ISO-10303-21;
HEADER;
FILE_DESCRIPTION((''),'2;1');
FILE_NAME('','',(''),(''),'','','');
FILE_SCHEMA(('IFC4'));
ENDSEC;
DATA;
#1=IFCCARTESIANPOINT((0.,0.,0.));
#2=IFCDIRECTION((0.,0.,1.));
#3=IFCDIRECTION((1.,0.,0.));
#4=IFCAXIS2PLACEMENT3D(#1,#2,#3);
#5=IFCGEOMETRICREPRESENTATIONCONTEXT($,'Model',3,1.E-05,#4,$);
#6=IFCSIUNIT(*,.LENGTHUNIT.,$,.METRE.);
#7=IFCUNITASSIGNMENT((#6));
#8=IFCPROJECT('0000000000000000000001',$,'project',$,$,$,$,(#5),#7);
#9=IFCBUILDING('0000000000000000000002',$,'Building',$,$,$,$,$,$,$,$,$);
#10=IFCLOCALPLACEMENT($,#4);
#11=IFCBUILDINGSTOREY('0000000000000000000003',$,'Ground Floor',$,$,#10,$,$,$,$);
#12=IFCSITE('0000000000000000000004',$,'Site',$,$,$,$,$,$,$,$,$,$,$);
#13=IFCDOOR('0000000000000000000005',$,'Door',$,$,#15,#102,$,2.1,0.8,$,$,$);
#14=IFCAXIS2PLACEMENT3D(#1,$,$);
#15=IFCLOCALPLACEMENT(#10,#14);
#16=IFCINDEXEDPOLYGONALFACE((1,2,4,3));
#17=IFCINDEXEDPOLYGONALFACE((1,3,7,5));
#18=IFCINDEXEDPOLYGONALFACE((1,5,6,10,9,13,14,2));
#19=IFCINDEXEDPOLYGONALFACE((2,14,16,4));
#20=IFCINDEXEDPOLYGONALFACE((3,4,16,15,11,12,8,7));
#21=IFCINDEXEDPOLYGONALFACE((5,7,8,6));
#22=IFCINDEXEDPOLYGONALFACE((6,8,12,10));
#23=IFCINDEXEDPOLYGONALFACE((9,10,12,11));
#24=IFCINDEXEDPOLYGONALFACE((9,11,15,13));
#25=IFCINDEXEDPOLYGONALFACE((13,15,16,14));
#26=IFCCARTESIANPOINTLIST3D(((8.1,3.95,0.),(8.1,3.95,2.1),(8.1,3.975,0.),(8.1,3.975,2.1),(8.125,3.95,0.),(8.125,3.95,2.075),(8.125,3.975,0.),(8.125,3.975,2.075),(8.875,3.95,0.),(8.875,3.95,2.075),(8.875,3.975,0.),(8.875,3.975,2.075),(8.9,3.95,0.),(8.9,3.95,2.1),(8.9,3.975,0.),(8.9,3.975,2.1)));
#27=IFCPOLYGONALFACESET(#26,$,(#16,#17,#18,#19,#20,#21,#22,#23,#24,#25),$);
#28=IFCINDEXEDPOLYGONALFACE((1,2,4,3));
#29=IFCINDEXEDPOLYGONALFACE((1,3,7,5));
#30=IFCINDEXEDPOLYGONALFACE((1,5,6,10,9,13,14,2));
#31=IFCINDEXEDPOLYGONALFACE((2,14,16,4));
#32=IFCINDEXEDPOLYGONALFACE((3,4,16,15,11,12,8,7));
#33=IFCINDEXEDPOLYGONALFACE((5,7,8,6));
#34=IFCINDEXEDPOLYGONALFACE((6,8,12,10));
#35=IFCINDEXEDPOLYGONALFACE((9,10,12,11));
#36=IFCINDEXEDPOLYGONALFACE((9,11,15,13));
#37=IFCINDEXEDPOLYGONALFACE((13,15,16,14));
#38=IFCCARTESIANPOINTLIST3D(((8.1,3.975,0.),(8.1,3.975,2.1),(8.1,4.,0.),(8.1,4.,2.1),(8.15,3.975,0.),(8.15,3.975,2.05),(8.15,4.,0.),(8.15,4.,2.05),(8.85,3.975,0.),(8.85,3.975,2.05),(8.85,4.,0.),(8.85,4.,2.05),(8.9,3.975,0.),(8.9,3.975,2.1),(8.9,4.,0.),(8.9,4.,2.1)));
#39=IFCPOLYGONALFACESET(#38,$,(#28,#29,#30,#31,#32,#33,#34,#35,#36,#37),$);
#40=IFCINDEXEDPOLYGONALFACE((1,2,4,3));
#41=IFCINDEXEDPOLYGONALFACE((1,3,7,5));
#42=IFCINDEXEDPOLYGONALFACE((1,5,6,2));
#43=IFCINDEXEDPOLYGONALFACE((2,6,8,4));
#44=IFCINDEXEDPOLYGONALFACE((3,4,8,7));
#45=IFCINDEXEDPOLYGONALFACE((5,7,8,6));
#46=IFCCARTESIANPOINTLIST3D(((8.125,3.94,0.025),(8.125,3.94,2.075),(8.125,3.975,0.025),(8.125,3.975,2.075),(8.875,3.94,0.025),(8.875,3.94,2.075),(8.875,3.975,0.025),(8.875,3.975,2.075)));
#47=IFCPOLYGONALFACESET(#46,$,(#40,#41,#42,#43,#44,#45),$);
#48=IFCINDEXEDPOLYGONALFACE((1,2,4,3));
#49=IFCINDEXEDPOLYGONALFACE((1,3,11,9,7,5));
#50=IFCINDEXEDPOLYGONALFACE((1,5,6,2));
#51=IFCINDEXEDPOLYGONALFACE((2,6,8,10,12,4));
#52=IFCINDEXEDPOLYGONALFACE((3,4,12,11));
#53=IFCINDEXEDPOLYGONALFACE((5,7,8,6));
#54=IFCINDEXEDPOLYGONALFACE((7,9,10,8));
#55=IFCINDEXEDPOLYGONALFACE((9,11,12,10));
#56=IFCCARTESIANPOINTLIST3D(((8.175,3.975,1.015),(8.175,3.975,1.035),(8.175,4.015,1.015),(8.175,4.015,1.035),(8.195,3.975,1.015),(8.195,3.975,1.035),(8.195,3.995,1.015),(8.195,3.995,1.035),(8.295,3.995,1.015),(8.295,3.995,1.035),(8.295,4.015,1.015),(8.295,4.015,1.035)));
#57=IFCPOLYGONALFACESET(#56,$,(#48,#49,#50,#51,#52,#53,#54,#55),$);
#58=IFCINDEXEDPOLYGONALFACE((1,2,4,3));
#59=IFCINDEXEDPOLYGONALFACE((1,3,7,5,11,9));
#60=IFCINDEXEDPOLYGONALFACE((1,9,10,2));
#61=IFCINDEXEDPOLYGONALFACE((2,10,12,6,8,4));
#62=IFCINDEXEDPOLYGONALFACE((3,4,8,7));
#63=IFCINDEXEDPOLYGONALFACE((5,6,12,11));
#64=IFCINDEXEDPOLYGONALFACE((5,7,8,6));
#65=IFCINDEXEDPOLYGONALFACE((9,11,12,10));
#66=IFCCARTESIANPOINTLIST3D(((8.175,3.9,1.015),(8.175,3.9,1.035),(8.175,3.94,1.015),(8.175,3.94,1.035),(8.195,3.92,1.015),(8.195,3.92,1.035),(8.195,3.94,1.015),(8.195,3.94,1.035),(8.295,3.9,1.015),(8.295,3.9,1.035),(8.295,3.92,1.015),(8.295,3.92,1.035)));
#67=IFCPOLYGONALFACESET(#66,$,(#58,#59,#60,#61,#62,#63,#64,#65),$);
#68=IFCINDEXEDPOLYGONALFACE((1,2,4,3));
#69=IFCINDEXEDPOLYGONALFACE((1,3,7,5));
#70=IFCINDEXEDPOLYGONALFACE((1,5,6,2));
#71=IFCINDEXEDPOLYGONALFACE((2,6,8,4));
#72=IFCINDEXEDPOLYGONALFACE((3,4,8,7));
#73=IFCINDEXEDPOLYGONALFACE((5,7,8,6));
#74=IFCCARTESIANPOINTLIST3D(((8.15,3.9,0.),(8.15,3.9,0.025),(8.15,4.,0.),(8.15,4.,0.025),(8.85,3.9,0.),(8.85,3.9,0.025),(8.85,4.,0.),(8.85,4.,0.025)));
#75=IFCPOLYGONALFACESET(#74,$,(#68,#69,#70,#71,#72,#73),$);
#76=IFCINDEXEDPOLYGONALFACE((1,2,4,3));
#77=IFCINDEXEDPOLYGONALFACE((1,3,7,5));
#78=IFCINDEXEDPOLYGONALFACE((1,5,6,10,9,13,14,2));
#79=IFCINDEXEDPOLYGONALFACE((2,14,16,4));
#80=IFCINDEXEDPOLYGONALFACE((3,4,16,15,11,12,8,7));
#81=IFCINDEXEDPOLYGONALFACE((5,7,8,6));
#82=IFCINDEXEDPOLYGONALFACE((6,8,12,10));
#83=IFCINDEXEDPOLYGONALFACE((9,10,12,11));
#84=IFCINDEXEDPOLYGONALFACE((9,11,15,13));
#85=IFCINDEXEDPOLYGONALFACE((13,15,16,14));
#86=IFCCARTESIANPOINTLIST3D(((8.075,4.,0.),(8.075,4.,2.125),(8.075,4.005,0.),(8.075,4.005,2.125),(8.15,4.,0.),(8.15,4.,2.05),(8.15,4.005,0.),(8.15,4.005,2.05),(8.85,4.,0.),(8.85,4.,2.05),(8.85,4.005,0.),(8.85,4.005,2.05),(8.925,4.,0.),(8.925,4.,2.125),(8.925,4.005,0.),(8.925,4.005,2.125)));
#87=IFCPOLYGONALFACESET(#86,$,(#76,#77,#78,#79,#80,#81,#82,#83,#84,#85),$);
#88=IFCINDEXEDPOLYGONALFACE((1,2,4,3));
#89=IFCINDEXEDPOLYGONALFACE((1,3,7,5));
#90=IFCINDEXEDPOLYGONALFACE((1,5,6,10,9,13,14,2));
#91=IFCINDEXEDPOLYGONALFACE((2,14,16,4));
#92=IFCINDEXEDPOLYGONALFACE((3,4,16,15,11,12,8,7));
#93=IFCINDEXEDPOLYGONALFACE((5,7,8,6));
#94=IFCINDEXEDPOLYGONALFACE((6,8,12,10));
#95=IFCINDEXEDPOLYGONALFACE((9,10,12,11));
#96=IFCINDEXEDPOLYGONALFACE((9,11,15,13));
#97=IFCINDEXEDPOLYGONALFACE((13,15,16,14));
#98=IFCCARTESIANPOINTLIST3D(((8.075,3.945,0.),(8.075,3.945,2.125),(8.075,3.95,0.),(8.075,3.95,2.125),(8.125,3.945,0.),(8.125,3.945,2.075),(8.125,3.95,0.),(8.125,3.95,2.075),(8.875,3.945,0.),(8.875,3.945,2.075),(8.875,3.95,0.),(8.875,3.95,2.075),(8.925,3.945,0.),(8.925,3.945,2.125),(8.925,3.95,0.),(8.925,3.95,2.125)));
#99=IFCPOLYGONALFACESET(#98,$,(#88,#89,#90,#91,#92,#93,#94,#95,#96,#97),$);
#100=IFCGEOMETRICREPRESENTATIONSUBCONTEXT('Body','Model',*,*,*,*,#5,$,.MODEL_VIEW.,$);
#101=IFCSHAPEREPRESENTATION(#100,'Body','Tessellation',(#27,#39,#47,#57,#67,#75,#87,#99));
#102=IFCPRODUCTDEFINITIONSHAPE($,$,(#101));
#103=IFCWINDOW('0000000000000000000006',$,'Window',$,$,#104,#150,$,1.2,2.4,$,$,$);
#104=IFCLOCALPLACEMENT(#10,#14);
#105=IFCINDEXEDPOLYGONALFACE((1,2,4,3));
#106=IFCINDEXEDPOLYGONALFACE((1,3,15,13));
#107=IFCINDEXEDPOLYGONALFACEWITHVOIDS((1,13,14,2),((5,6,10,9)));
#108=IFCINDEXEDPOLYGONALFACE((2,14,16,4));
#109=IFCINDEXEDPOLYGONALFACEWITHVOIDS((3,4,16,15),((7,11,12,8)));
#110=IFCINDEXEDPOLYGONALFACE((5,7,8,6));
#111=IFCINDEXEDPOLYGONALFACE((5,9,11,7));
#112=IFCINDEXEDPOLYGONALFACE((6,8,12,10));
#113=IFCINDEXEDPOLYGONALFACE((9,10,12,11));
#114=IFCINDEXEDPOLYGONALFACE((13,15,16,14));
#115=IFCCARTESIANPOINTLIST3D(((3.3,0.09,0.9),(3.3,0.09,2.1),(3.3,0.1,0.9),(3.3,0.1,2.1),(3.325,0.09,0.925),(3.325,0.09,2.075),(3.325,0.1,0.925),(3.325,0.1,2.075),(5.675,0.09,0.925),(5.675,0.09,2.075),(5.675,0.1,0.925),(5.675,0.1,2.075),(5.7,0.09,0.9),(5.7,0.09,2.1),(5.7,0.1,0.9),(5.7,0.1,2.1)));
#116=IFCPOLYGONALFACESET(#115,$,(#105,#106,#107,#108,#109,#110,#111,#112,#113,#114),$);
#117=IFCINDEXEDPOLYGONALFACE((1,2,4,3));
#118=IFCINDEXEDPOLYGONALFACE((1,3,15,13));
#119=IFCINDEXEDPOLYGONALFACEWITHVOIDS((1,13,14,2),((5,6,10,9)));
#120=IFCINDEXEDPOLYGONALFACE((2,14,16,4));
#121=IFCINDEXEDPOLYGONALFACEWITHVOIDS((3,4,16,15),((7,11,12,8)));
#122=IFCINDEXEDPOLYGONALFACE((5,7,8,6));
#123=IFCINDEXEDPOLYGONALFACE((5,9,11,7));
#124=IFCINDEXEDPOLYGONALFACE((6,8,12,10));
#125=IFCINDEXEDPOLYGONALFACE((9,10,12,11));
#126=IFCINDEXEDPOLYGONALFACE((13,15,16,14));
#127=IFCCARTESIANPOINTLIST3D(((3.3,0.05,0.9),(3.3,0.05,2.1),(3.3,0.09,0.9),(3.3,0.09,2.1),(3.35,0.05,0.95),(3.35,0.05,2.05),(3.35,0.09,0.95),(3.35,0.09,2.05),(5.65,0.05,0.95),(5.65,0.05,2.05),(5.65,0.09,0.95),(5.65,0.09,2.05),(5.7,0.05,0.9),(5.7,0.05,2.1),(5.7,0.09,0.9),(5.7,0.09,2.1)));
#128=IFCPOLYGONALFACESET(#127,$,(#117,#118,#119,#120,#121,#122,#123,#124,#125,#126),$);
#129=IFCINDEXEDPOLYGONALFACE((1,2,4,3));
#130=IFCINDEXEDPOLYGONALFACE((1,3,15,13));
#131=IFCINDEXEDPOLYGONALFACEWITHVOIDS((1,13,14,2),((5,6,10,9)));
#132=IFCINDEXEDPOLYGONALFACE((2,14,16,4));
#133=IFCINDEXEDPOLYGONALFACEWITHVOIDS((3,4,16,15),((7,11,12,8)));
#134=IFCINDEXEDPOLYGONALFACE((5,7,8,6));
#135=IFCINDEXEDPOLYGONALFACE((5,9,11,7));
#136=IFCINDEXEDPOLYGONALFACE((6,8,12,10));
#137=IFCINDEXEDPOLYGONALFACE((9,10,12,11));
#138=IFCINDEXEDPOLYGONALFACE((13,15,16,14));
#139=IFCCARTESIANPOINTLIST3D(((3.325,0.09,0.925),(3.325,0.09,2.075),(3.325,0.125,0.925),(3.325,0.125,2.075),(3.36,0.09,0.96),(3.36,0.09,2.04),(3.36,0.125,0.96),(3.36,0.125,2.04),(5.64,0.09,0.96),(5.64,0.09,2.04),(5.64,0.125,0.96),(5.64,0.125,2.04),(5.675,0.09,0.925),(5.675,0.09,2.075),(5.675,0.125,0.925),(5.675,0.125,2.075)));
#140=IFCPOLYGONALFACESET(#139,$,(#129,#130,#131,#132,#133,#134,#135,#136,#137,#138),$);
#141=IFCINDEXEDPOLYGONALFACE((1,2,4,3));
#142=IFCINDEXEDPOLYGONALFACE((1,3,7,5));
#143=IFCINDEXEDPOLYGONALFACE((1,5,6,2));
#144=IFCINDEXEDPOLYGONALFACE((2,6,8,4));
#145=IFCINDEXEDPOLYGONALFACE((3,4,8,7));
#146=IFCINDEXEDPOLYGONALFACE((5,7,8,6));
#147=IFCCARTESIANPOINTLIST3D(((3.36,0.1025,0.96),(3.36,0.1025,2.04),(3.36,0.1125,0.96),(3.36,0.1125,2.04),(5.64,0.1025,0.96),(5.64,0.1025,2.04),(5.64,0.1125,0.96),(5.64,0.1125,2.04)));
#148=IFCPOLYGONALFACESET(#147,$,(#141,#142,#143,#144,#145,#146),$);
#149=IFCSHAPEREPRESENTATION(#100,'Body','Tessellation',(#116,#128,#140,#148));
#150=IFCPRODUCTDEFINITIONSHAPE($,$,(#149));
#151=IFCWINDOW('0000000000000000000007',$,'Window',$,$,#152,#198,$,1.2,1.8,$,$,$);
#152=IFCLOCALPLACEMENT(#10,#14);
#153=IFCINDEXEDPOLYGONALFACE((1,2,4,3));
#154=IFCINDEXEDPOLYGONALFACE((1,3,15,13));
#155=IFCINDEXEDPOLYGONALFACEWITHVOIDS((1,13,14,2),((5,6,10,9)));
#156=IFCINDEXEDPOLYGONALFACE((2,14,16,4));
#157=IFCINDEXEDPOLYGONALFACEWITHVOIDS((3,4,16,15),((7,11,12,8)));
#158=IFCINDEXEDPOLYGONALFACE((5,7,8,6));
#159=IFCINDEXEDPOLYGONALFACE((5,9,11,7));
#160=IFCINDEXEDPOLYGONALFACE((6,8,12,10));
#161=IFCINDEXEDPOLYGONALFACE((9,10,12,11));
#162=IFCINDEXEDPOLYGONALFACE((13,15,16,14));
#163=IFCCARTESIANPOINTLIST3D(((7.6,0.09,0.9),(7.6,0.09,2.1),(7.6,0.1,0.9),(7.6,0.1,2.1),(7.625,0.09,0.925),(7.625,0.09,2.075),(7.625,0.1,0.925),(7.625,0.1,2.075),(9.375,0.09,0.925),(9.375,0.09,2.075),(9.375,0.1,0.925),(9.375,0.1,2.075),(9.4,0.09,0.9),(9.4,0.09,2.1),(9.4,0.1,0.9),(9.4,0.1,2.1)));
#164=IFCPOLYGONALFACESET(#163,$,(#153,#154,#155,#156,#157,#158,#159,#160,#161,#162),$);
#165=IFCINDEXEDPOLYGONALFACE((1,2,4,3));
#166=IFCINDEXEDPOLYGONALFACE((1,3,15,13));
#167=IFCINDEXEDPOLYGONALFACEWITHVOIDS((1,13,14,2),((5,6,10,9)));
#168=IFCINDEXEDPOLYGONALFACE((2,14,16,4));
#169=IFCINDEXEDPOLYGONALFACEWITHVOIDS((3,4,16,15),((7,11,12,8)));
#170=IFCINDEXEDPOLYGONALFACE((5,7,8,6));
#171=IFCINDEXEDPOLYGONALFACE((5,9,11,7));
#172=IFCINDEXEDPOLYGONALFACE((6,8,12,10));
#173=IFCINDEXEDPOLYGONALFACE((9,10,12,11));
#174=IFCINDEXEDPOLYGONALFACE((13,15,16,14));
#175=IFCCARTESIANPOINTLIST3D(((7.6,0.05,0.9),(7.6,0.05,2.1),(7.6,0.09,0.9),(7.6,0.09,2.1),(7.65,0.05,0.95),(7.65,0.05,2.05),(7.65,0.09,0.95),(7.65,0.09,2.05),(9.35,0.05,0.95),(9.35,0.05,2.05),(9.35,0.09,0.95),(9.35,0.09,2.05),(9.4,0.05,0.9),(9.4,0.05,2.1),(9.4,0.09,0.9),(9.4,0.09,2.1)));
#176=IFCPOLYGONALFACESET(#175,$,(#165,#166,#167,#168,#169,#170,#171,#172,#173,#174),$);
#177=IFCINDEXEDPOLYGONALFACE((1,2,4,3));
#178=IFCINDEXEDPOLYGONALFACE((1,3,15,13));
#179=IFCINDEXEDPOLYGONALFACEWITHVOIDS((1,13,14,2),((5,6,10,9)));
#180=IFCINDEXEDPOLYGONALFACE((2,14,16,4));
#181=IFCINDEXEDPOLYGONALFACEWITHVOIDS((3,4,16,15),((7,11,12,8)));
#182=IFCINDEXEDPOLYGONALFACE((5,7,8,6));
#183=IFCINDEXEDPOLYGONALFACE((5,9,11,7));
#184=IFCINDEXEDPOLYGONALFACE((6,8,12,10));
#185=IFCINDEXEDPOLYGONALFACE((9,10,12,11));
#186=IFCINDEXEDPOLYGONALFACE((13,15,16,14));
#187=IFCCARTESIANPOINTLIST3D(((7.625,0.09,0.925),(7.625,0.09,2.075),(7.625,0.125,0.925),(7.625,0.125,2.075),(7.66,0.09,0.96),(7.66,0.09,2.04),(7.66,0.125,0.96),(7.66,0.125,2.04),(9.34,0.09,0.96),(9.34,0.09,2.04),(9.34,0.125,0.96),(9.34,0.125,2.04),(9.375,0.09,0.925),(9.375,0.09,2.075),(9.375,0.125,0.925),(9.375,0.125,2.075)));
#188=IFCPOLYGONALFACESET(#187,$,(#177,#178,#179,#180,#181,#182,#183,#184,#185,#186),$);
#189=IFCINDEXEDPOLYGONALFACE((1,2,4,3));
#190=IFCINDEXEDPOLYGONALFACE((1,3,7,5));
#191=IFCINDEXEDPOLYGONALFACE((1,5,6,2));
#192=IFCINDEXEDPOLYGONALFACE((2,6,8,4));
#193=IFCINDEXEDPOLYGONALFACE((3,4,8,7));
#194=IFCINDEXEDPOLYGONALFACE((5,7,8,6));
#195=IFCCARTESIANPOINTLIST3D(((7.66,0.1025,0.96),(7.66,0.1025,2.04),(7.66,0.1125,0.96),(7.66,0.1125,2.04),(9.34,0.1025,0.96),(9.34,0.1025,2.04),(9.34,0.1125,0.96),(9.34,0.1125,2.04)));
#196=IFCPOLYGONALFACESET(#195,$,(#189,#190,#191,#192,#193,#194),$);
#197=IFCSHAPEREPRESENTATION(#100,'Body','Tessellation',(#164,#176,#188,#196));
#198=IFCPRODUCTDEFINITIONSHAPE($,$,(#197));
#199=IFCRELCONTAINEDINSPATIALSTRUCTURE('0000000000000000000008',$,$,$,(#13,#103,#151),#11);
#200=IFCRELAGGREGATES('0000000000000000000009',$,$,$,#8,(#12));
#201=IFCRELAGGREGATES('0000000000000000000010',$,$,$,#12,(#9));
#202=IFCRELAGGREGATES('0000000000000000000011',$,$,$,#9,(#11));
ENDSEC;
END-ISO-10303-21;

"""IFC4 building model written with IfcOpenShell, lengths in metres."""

from ifc_helpers import new_model, si_unit, frame, origin_with_axes, place, context, subcontext, project, spatial, line, indexed_curve, outline, extrude, element, save


model = new_model("IFC4")

# Units and contexts
model_context = context("Model", 3, precision=1e-05, world=origin_with_axes())
body_context = subcontext(model_context, "Body", "Model", "MODEL_VIEW")
ifc_project = project(units=[si_unit("LENGTHUNIT", "METRE")], contexts=[model_context])

# Site, building, storey
site = spatial("IfcSite", under=ifc_project, Name="Site")
building = spatial("IfcBuilding", under=site, Name="Building")
storey_placement = place(None, origin_with_axes())
storey = spatial("IfcBuildingStorey", under=building, at=storey_placement, Name="Ground Floor")

# Door
door_1_placement = place(storey_placement, frame((8.9, 4.0, 0.0), z_axis=(0.0, 0.0, 1.0), x_axis=(-1.0, 0.0, 0.0)))
element("IfcDoor", 1, at=door_1_placement, inside=storey, Name="Door", OverallHeight=2.1, OverallWidth=0.8, context=body_context, shape_type="SweptSolid", body=[
    extrude(outline(indexed_curve([(0.0, 0.0), (0.0, 2.1), (0.8, 2.1), (0.8, 0.0), (0.775, 0.0), (0.775, 2.075), (0.025, 2.075), (0.025, 0.0)], segments=[line(1, 2, 3, 4, 5, 6, 7, 8, 1)])), frame((0.0, 0.025, 0.0), z_axis=(0.0, -1.0, 0.0), x_axis=(1.0, 0.0, 0.0)), (0.0, 0.0, -1.0), 0.025),
    extrude(outline(indexed_curve([(0.0, 0.0), (0.0, 2.1), (0.8, 2.1), (0.8, 0.0), (0.75, 0.0), (0.75, 2.05), (0.05, 2.05), (0.05, 0.0)], segments=[line(1, 2, 3, 4, 5, 6, 7, 8, 1)])), frame((0.0, 0.0, 0.0), z_axis=(0.0, -1.0, 0.0), x_axis=(1.0, 0.0, 0.0)), (0.0, 0.0, -1.0), 0.025),
    extrude(outline(indexed_curve([(0.0, 0.0), (0.75, 0.0), (0.75, 0.035), (0.0, 0.035)], segments=[line(1, 2, 3, 4, 1)])), frame((0.025, 0.025, 0.025), z_axis=(0.0, 0.0, 1.0), x_axis=(1.0, 0.0, 0.0)), (0.0, 0.0, 1.0), 2.05),
    extrude(outline(indexed_curve([(0.0, 0.0), (0.0, -0.04), (-0.12, -0.04), (-0.12, -0.02), (-0.02, -0.02), (-0.02, 0.0)], segments=[line(1, 2, 3, 4, 5, 6, 1)])), frame((0.725, 0.025, 1.015), z_axis=(0.0, 0.0, 1.0), x_axis=(1.0, 0.0, 0.0)), (0.0, 0.0, 1.0), 0.02),
    extrude(outline(indexed_curve([(0.0, 0.0), (0.0, 0.04), (-0.12, 0.04), (-0.12, 0.02), (-0.02, 0.02), (-0.02, 0.0)], segments=[line(1, 2, 3, 4, 5, 6, 1)])), frame((0.725, 0.06, 1.015), z_axis=(0.0, 0.0, 1.0), x_axis=(1.0, 0.0, 0.0)), (0.0, 0.0, 1.0), 0.02),
    extrude(outline(indexed_curve([(0.0, 0.0), (0.7, 0.0), (0.7, 0.1), (0.0, 0.1)], segments=[line(1, 2, 3, 4, 1)])), frame((0.05, 0.0, 0.0), z_axis=(0.0, 0.0, 1.0), x_axis=(1.0, 0.0, 0.0)), (0.0, 0.0, 1.0), 0.025),
    extrude(outline(indexed_curve([(0.0, 0.0), (0.0, 2.125), (0.85, 2.125), (0.85, 0.0), (0.775, 0.0), (0.775, 2.05), (0.075, 2.05), (0.075, 0.0)], segments=[line(1, 2, 3, 4, 5, 6, 7, 8, 1)])), frame((-0.025, -0.005, 0.0), z_axis=(0.0, -1.0, 0.0), x_axis=(1.0, 0.0, 0.0)), (0.0, 0.0, -1.0), 0.005),
    extrude(outline(indexed_curve([(0.0, 0.0), (0.0, 2.125), (0.85, 2.125), (0.85, 0.0), (0.8, 0.0), (0.8, 2.075), (0.05, 2.075), (0.05, 0.0)], segments=[line(1, 2, 3, 4, 5, 6, 7, 8, 1)])), frame((-0.025, 0.05, 0.0), z_axis=(0.0, -1.0, 0.0), x_axis=(1.0, 0.0, 0.0)), (0.0, 0.0, -1.0), 0.005),
])

# Windows
window_1_placement = place(storey_placement, frame((3.3, 0.0, 0.9), z_axis=(0.0, 0.0, 1.0), x_axis=(1.0, 0.0, 0.0)))
element("IfcWindow", 2, at=window_1_placement, inside=storey, Name="Window", OverallHeight=1.2, OverallWidth=2.4, context=body_context, shape_type="SweptSolid", body=[
    extrude(outline(indexed_curve([(0.0, 0.0), (2.4, 0.0), (2.4, 1.2), (0.0, 1.2)], segments=[line(1, 2, 3, 4, 1)]), holes=[indexed_curve([(0.025, 0.025), (2.375, 0.025), (2.375, 1.175), (0.025, 1.175)], segments=[line(1, 2, 3, 4, 1)])]), frame((0.0, 0.09, 0.0), z_axis=(0.0, -1.0, 0.0), x_axis=(1.0, 0.0, 0.0)), (0.0, 0.0, -1.0), 0.01),
    extrude(outline(indexed_curve([(0.0, 0.0), (2.4, 0.0), (2.4, 1.2), (0.0, 1.2)], segments=[line(1, 2, 3, 4, 1)]), holes=[indexed_curve([(0.05, 0.05), (2.35, 0.05), (2.35, 1.15), (0.05, 1.15)], segments=[line(1, 2, 3, 4, 1)])]), frame((0.0, 0.05, 0.0), z_axis=(0.0, -1.0, 0.0), x_axis=(1.0, 0.0, 0.0)), (0.0, 0.0, -1.0), 0.04),
    extrude(outline(indexed_curve([(0.0, 0.0), (2.35, 0.0), (2.35, 1.15), (0.0, 1.15)], segments=[line(1, 2, 3, 4, 1)]), holes=[indexed_curve([(0.035, 0.035), (2.315, 0.035), (2.315, 1.115), (0.035, 1.115)], segments=[line(1, 2, 3, 4, 1)])]), frame((0.025, 0.09, 0.025), z_axis=(0.0, -1.0, 0.0), x_axis=(1.0, 0.0, 0.0)), (0.0, 0.0, -1.0), 0.035),
    extrude(outline(indexed_curve([(0.035, 0.035), (2.315, 0.035), (2.315, 1.115), (0.035, 1.115)], segments=[line(1, 2, 3, 4, 1)])), frame((0.025, 0.1025, 0.025), z_axis=(0.0, -1.0, 0.0), x_axis=(1.0, 0.0, 0.0)), (0.0, 0.0, -1.0), 0.01),
])
window_2_placement = place(storey_placement, frame((7.6, 0.0, 0.9), z_axis=(0.0, 0.0, 1.0), x_axis=(1.0, 0.0, 0.0)))
element("IfcWindow", 3, at=window_2_placement, inside=storey, Name="Window", OverallHeight=1.2, OverallWidth=1.8, context=body_context, shape_type="SweptSolid", body=[
    extrude(outline(indexed_curve([(0.0, 0.0), (1.8, 0.0), (1.8, 1.2), (0.0, 1.2)], segments=[line(1, 2, 3, 4, 1)]), holes=[indexed_curve([(0.025, 0.025), (1.775, 0.025), (1.775, 1.175), (0.025, 1.175)], segments=[line(1, 2, 3, 4, 1)])]), frame((0.0, 0.09, 0.0), z_axis=(0.0, -1.0, 0.0), x_axis=(1.0, 0.0, 0.0)), (0.0, 0.0, -1.0), 0.01),
    extrude(outline(indexed_curve([(0.0, 0.0), (1.8, 0.0), (1.8, 1.2), (0.0, 1.2)], segments=[line(1, 2, 3, 4, 1)]), holes=[indexed_curve([(0.05, 0.05), (1.75, 0.05), (1.75, 1.15), (0.05, 1.15)], segments=[line(1, 2, 3, 4, 1)])]), frame((0.0, 0.05, 0.0), z_axis=(0.0, -1.0, 0.0), x_axis=(1.0, 0.0, 0.0)), (0.0, 0.0, -1.0), 0.04),
    extrude(outline(indexed_curve([(0.0, 0.0), (1.75, 0.0), (1.75, 1.15), (0.0, 1.15)], segments=[line(1, 2, 3, 4, 1)]), holes=[indexed_curve([(0.035, 0.035), (1.715, 0.035), (1.715, 1.115), (0.035, 1.115)], segments=[line(1, 2, 3, 4, 1)])]), frame((0.025, 0.09, 0.025), z_axis=(0.0, -1.0, 0.0), x_axis=(1.0, 0.0, 0.0)), (0.0, 0.0, -1.0), 0.035),
    extrude(outline(indexed_curve([(0.035, 0.035), (1.715, 0.035), (1.715, 1.115), (0.035, 1.115)], segments=[line(1, 2, 3, 4, 1)])), frame((0.025, 0.1025, 0.025), z_axis=(0.0, -1.0, 0.0), x_axis=(1.0, 0.0, 0.0)), (0.0, 0.0, -1.0), 0.01),
])

save(model, "model.ifc")
